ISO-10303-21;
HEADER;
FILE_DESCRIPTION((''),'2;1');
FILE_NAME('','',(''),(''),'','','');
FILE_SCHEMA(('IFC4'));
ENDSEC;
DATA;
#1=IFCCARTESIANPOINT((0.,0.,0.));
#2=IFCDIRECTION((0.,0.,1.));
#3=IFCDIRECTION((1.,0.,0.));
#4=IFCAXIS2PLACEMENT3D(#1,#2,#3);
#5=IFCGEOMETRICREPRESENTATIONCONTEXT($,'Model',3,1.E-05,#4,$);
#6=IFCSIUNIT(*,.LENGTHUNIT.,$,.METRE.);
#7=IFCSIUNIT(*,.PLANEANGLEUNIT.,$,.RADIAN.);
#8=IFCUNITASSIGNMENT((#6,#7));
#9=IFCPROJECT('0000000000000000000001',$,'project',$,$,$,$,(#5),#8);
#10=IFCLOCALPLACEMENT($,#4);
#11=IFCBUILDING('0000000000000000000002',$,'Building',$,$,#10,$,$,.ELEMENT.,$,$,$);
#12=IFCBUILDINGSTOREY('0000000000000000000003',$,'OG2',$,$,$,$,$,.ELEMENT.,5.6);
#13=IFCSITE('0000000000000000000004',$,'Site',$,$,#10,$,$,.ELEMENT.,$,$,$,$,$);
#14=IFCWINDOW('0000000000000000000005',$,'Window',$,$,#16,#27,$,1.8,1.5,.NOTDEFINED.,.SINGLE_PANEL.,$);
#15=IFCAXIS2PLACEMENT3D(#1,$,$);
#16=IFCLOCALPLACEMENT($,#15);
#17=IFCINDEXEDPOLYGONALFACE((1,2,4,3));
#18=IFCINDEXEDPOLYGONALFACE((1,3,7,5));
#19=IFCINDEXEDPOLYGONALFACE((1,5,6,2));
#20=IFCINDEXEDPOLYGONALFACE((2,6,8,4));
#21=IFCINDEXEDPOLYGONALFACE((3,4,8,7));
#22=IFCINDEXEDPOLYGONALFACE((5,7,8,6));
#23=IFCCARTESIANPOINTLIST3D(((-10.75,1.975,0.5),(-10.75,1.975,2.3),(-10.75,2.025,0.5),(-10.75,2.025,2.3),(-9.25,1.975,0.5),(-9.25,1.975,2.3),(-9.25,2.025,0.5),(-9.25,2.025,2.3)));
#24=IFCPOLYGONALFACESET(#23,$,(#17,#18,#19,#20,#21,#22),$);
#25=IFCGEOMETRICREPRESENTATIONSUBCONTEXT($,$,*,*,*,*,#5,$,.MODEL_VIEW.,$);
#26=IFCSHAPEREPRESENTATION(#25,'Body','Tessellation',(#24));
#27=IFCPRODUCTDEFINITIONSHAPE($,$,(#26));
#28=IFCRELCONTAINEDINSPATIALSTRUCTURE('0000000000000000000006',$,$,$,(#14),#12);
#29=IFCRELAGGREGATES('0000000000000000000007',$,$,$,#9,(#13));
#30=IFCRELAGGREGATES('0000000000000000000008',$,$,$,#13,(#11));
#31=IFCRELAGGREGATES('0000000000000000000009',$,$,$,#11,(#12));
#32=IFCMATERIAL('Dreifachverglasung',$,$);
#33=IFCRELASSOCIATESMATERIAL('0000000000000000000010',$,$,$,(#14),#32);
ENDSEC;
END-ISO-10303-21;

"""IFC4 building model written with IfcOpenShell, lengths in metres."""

from ifc_helpers import new_model, si_unit, frame, origin, origin_with_axes, origin_2d, place, context, subcontext, project, spatial, rectangle, extrude, material, element, save


model = new_model("IFC4")

# Units and contexts
model_context = context("Model", 3, precision=1e-05, world=origin_with_axes())
sub_context = subcontext(model_context, None, None, "MODEL_VIEW")
ifc_project = project(units=[si_unit("LENGTHUNIT", "METRE"), si_unit("PLANEANGLEUNIT", "RADIAN")], contexts=[model_context])

# Site, building, storey
placement_1 = place(None, origin_with_axes())
site = spatial("IfcSite", under=ifc_project, at=placement_1, Name="Site", CompositionType="ELEMENT")
building = spatial("IfcBuilding", under=site, at=placement_1, Name="Building", CompositionType="ELEMENT")
storey = spatial("IfcBuildingStorey", under=building, Name="OG2", CompositionType="ELEMENT", Elevation=5.6)

# Window
ifc_material = material(Name="Dreifachverglasung")
placement_2 = place(None, origin_with_axes())
window_placement = place(placement_2, frame((-10.0, 2.0, 0.5)))
element("IfcWindow", 1, at=window_placement, inside=storey, material=ifc_material, Name="Window", OverallHeight=1.8, OverallWidth=1.5, PartitioningType="SINGLE_PANEL", PredefinedType="NOTDEFINED", context=sub_context, shape_type="SweptSolid", body=[
    extrude(rectangle(XDim=1.5, YDim=0.05, at=origin_2d()), origin(), (0.0, 0.0, 1.0), 1.8),
])

save(model, "model.ifc")
